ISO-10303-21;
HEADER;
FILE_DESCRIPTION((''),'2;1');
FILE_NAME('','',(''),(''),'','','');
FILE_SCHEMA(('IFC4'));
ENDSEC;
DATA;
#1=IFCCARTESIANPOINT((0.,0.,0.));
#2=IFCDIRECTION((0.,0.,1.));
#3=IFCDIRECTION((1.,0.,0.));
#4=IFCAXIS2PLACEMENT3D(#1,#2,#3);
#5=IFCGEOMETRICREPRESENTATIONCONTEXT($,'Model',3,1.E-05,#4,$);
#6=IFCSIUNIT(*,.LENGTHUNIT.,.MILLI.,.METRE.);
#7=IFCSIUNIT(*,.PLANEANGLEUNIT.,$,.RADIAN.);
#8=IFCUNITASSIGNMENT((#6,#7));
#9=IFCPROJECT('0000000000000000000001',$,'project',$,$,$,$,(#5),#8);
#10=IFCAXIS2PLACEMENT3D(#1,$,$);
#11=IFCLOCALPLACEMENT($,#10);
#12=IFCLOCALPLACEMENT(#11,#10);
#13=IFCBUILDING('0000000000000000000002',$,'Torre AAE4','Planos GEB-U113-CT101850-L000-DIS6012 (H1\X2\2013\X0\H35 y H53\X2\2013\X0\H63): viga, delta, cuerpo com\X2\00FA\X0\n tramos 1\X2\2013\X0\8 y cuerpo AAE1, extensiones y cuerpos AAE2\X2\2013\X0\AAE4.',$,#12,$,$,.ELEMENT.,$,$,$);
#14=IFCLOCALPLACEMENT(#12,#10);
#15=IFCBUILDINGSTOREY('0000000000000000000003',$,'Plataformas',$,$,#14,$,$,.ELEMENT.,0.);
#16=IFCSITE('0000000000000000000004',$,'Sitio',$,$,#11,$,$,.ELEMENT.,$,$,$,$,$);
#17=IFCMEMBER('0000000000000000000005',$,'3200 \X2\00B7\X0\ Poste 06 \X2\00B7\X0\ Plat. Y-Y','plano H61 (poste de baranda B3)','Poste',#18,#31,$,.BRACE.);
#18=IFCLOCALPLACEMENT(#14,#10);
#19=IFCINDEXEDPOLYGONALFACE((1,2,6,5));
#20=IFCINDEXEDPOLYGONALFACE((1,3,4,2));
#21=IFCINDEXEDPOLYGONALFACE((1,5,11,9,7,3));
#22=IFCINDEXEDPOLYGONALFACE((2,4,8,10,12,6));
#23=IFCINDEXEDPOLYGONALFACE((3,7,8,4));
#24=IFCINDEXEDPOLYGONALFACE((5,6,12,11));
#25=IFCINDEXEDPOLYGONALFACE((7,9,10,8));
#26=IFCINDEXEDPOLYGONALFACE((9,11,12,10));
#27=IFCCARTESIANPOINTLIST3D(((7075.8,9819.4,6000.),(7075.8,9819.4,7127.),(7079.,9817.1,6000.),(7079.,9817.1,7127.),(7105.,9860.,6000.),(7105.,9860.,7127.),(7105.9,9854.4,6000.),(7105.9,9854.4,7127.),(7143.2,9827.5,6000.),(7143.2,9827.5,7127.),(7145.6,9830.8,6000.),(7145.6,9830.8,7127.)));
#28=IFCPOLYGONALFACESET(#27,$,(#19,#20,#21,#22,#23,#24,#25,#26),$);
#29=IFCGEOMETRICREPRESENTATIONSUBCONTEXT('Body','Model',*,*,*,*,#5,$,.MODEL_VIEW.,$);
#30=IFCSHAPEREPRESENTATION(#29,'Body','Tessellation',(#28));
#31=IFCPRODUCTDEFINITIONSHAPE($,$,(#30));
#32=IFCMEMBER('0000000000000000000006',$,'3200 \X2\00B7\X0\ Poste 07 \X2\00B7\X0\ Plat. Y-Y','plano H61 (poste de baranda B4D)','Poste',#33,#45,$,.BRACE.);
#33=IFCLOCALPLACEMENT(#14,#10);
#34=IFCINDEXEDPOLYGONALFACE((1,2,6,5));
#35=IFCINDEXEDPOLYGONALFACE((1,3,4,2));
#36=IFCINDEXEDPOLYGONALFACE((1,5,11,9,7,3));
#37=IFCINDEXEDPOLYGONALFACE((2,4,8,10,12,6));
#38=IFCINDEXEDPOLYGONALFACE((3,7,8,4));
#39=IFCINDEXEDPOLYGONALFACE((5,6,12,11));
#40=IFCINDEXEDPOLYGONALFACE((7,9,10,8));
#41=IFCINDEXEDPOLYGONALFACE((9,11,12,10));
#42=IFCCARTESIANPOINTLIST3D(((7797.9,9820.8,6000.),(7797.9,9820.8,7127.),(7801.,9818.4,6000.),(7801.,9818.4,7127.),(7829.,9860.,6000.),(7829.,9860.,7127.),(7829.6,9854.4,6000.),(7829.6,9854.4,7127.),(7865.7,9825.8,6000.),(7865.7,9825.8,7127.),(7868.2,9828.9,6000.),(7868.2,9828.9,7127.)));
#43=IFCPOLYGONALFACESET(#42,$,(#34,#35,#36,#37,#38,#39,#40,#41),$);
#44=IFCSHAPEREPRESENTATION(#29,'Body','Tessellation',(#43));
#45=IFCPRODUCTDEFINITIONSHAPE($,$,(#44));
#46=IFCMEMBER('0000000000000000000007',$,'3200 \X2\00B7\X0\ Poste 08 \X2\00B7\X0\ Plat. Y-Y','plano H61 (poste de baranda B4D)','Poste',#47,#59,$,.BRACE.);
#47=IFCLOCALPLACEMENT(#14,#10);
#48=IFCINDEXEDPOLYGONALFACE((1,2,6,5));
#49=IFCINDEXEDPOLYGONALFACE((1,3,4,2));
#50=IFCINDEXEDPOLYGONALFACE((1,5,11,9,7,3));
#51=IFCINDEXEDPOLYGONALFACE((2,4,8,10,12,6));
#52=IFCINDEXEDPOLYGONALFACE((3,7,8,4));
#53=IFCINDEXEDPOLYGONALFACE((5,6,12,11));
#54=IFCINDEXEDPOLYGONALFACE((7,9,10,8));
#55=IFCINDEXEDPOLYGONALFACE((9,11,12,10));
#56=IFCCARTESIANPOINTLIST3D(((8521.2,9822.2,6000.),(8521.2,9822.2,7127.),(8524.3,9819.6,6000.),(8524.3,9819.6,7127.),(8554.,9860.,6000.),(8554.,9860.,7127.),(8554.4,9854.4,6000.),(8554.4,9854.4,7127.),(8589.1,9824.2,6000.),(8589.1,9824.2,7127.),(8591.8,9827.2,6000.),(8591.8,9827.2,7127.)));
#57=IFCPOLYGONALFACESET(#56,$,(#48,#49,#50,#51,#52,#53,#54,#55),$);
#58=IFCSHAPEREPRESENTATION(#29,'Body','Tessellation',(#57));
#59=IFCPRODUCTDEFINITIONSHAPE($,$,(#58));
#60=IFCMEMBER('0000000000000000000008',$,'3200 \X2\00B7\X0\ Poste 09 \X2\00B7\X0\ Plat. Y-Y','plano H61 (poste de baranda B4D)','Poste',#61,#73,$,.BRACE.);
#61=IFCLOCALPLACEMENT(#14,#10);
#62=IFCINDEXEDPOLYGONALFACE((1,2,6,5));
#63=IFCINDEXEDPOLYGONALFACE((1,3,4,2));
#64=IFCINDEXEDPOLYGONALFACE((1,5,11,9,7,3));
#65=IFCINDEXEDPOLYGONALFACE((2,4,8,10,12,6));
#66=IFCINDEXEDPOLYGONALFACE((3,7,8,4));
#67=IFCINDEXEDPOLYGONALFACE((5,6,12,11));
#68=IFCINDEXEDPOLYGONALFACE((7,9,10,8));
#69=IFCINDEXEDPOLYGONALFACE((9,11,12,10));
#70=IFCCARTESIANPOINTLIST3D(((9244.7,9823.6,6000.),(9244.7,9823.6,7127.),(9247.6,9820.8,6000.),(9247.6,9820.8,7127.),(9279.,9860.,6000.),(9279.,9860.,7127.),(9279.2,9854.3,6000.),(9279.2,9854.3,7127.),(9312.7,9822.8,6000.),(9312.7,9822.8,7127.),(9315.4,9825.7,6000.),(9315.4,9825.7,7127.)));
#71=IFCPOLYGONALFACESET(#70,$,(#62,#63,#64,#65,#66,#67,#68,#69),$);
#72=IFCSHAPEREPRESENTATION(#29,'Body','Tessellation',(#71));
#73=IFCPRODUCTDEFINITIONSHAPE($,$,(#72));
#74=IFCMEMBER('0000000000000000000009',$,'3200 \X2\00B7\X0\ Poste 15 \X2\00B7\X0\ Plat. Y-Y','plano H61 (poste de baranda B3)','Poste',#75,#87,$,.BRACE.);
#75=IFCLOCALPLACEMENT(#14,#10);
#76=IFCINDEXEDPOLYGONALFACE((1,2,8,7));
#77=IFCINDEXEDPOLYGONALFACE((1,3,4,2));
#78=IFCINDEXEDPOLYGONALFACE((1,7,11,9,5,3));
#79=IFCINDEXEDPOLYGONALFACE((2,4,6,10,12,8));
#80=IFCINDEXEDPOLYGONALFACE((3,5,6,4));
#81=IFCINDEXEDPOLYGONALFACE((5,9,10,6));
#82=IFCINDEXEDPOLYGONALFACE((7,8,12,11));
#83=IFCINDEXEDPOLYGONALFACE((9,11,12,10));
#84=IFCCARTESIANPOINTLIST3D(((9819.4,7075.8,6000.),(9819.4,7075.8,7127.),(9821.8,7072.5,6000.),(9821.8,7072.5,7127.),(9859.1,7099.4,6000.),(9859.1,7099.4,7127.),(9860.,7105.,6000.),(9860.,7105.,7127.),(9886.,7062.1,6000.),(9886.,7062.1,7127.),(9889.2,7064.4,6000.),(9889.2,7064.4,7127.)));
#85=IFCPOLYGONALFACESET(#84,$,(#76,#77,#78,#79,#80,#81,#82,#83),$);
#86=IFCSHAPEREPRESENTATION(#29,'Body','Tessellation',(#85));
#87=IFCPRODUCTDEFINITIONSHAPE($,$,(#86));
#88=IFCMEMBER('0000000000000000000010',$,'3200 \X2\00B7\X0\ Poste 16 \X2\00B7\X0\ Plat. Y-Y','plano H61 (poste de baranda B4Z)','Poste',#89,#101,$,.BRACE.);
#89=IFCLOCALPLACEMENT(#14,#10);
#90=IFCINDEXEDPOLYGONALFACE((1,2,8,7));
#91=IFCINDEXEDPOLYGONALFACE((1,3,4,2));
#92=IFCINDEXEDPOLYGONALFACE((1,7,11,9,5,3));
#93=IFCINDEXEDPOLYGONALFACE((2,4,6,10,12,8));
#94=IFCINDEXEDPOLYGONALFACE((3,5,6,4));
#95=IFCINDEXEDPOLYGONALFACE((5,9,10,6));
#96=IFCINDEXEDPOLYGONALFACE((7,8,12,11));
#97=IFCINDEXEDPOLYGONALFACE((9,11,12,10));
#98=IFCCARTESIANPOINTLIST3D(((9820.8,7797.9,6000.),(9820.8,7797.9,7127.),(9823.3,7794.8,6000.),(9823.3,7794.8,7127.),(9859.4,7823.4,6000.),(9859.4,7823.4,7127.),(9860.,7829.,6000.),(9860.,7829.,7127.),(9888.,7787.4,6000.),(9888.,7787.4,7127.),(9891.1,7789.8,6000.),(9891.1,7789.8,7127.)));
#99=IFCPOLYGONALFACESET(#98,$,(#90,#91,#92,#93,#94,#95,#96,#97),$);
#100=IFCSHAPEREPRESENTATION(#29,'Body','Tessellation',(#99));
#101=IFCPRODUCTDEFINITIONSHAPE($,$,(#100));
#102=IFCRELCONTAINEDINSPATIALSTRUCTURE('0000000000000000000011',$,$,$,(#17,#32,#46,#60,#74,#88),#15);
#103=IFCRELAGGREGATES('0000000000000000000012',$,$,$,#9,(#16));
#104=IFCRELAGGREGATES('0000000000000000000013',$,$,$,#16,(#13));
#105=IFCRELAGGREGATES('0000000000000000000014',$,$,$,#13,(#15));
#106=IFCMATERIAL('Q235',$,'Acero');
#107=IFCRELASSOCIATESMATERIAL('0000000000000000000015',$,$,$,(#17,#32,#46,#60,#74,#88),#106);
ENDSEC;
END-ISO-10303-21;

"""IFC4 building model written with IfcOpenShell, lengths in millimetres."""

from ifc_helpers import new_model, si_unit, frame, frame_2d, origin, origin_with_axes, place, context, subcontext, project, spatial, l_section, extrude, material, element, save


model = new_model("IFC4")

# Units and contexts
model_context = context("Model", 3, precision=1e-05, world=origin_with_axes())
body_context = subcontext(model_context, "Body", "Model", "MODEL_VIEW")
ifc_project = project(units=[si_unit("LENGTHUNIT", "METRE", prefix="MILLI"), si_unit("PLANEANGLEUNIT", "RADIAN")], contexts=[model_context])

# Site, building, storey
site_placement = place(None, origin())
site = spatial("IfcSite", under=ifc_project, at=site_placement, Name="Sitio", CompositionType="ELEMENT")
building_placement = place(site_placement, origin())
building = spatial("IfcBuilding", under=site, at=building_placement, Name="Torre AAE4", Description="Planos GEB-U113-CT101850-L000-DIS6012 (H1–H35 y H53–H63): viga, delta, cuerpo común tramos 1–8 y cuerpo AAE1, extensiones y cuerpos AAE2–AAE4.", CompositionType="ELEMENT")
storey_placement = place(building_placement, origin())
storey = spatial("IfcBuildingStorey", under=building, at=storey_placement, Name="Plataformas", CompositionType="ELEMENT", Elevation=0.0)

# Members
ifc_material = material(Name="Q235", Category="Acero")
for number, where, z_axis, x_axis, name, description in (
    (1, (7105.0, 9860.0, 6000.0), (0.0, 0.0, 1.0), (-0.584619, -0.811308, 0.0), "3200 · Poste 06 · Plat. Y-Y", "plano H61 (poste de baranda B3)"),
    (2, (7829.0, 9860.0, 6000.0), (0.0, 0.0, 1.0), (-0.621833, -0.78315, 0.0), "3200 · Poste 07 · Plat. Y-Y", "plano H61 (poste de baranda B4D)"),
    (3, (8554.0, 9860.0, 6000.0), (0.0, 0.0, 1.0), (-0.65531, -0.75536, 0.0), "3200 · Poste 08 · Plat. Y-Y", "plano H61 (poste de baranda B4D)"),
    (4, (9279.0, 9860.0, 6000.0), (0.0, 0.0, 1.0), (-0.685326, -0.728237, 0.0), "3200 · Poste 09 · Plat. Y-Y", "plano H61 (poste de baranda B4D)"),
    (5, (9860.0, 7105.0, 6000.0), (0.0, 0.0, 1.0), (-0.811308, -0.584619, 0.0), "3200 · Poste 15 · Plat. Y-Y", "plano H61 (poste de baranda B3)"),
    (6, (9860.0, 7829.0, 6000.0), (0.0, 0.0, 1.0), (-0.78315, -0.621833, 0.0), "3200 · Poste 16 · Plat. Y-Y", "plano H61 (poste de baranda B4Z)"),
):
    element("IfcMember", number, at=place(storey_placement, frame(where, z_axis=z_axis, x_axis=x_axis)), inside=storey, material=ifc_material, Name=name, Description=description, ObjectType="Poste", PredefinedType="BRACE", context=body_context, shape_type="SweptSolid", body=[
        extrude(l_section(Depth=50.0, Width=50.0, Thickness=4.0, at=frame_2d((25.0, 25.0))), None, (0.0, 0.0, 1.0), 1127.0),
    ])

save(model, "model.ifc")
